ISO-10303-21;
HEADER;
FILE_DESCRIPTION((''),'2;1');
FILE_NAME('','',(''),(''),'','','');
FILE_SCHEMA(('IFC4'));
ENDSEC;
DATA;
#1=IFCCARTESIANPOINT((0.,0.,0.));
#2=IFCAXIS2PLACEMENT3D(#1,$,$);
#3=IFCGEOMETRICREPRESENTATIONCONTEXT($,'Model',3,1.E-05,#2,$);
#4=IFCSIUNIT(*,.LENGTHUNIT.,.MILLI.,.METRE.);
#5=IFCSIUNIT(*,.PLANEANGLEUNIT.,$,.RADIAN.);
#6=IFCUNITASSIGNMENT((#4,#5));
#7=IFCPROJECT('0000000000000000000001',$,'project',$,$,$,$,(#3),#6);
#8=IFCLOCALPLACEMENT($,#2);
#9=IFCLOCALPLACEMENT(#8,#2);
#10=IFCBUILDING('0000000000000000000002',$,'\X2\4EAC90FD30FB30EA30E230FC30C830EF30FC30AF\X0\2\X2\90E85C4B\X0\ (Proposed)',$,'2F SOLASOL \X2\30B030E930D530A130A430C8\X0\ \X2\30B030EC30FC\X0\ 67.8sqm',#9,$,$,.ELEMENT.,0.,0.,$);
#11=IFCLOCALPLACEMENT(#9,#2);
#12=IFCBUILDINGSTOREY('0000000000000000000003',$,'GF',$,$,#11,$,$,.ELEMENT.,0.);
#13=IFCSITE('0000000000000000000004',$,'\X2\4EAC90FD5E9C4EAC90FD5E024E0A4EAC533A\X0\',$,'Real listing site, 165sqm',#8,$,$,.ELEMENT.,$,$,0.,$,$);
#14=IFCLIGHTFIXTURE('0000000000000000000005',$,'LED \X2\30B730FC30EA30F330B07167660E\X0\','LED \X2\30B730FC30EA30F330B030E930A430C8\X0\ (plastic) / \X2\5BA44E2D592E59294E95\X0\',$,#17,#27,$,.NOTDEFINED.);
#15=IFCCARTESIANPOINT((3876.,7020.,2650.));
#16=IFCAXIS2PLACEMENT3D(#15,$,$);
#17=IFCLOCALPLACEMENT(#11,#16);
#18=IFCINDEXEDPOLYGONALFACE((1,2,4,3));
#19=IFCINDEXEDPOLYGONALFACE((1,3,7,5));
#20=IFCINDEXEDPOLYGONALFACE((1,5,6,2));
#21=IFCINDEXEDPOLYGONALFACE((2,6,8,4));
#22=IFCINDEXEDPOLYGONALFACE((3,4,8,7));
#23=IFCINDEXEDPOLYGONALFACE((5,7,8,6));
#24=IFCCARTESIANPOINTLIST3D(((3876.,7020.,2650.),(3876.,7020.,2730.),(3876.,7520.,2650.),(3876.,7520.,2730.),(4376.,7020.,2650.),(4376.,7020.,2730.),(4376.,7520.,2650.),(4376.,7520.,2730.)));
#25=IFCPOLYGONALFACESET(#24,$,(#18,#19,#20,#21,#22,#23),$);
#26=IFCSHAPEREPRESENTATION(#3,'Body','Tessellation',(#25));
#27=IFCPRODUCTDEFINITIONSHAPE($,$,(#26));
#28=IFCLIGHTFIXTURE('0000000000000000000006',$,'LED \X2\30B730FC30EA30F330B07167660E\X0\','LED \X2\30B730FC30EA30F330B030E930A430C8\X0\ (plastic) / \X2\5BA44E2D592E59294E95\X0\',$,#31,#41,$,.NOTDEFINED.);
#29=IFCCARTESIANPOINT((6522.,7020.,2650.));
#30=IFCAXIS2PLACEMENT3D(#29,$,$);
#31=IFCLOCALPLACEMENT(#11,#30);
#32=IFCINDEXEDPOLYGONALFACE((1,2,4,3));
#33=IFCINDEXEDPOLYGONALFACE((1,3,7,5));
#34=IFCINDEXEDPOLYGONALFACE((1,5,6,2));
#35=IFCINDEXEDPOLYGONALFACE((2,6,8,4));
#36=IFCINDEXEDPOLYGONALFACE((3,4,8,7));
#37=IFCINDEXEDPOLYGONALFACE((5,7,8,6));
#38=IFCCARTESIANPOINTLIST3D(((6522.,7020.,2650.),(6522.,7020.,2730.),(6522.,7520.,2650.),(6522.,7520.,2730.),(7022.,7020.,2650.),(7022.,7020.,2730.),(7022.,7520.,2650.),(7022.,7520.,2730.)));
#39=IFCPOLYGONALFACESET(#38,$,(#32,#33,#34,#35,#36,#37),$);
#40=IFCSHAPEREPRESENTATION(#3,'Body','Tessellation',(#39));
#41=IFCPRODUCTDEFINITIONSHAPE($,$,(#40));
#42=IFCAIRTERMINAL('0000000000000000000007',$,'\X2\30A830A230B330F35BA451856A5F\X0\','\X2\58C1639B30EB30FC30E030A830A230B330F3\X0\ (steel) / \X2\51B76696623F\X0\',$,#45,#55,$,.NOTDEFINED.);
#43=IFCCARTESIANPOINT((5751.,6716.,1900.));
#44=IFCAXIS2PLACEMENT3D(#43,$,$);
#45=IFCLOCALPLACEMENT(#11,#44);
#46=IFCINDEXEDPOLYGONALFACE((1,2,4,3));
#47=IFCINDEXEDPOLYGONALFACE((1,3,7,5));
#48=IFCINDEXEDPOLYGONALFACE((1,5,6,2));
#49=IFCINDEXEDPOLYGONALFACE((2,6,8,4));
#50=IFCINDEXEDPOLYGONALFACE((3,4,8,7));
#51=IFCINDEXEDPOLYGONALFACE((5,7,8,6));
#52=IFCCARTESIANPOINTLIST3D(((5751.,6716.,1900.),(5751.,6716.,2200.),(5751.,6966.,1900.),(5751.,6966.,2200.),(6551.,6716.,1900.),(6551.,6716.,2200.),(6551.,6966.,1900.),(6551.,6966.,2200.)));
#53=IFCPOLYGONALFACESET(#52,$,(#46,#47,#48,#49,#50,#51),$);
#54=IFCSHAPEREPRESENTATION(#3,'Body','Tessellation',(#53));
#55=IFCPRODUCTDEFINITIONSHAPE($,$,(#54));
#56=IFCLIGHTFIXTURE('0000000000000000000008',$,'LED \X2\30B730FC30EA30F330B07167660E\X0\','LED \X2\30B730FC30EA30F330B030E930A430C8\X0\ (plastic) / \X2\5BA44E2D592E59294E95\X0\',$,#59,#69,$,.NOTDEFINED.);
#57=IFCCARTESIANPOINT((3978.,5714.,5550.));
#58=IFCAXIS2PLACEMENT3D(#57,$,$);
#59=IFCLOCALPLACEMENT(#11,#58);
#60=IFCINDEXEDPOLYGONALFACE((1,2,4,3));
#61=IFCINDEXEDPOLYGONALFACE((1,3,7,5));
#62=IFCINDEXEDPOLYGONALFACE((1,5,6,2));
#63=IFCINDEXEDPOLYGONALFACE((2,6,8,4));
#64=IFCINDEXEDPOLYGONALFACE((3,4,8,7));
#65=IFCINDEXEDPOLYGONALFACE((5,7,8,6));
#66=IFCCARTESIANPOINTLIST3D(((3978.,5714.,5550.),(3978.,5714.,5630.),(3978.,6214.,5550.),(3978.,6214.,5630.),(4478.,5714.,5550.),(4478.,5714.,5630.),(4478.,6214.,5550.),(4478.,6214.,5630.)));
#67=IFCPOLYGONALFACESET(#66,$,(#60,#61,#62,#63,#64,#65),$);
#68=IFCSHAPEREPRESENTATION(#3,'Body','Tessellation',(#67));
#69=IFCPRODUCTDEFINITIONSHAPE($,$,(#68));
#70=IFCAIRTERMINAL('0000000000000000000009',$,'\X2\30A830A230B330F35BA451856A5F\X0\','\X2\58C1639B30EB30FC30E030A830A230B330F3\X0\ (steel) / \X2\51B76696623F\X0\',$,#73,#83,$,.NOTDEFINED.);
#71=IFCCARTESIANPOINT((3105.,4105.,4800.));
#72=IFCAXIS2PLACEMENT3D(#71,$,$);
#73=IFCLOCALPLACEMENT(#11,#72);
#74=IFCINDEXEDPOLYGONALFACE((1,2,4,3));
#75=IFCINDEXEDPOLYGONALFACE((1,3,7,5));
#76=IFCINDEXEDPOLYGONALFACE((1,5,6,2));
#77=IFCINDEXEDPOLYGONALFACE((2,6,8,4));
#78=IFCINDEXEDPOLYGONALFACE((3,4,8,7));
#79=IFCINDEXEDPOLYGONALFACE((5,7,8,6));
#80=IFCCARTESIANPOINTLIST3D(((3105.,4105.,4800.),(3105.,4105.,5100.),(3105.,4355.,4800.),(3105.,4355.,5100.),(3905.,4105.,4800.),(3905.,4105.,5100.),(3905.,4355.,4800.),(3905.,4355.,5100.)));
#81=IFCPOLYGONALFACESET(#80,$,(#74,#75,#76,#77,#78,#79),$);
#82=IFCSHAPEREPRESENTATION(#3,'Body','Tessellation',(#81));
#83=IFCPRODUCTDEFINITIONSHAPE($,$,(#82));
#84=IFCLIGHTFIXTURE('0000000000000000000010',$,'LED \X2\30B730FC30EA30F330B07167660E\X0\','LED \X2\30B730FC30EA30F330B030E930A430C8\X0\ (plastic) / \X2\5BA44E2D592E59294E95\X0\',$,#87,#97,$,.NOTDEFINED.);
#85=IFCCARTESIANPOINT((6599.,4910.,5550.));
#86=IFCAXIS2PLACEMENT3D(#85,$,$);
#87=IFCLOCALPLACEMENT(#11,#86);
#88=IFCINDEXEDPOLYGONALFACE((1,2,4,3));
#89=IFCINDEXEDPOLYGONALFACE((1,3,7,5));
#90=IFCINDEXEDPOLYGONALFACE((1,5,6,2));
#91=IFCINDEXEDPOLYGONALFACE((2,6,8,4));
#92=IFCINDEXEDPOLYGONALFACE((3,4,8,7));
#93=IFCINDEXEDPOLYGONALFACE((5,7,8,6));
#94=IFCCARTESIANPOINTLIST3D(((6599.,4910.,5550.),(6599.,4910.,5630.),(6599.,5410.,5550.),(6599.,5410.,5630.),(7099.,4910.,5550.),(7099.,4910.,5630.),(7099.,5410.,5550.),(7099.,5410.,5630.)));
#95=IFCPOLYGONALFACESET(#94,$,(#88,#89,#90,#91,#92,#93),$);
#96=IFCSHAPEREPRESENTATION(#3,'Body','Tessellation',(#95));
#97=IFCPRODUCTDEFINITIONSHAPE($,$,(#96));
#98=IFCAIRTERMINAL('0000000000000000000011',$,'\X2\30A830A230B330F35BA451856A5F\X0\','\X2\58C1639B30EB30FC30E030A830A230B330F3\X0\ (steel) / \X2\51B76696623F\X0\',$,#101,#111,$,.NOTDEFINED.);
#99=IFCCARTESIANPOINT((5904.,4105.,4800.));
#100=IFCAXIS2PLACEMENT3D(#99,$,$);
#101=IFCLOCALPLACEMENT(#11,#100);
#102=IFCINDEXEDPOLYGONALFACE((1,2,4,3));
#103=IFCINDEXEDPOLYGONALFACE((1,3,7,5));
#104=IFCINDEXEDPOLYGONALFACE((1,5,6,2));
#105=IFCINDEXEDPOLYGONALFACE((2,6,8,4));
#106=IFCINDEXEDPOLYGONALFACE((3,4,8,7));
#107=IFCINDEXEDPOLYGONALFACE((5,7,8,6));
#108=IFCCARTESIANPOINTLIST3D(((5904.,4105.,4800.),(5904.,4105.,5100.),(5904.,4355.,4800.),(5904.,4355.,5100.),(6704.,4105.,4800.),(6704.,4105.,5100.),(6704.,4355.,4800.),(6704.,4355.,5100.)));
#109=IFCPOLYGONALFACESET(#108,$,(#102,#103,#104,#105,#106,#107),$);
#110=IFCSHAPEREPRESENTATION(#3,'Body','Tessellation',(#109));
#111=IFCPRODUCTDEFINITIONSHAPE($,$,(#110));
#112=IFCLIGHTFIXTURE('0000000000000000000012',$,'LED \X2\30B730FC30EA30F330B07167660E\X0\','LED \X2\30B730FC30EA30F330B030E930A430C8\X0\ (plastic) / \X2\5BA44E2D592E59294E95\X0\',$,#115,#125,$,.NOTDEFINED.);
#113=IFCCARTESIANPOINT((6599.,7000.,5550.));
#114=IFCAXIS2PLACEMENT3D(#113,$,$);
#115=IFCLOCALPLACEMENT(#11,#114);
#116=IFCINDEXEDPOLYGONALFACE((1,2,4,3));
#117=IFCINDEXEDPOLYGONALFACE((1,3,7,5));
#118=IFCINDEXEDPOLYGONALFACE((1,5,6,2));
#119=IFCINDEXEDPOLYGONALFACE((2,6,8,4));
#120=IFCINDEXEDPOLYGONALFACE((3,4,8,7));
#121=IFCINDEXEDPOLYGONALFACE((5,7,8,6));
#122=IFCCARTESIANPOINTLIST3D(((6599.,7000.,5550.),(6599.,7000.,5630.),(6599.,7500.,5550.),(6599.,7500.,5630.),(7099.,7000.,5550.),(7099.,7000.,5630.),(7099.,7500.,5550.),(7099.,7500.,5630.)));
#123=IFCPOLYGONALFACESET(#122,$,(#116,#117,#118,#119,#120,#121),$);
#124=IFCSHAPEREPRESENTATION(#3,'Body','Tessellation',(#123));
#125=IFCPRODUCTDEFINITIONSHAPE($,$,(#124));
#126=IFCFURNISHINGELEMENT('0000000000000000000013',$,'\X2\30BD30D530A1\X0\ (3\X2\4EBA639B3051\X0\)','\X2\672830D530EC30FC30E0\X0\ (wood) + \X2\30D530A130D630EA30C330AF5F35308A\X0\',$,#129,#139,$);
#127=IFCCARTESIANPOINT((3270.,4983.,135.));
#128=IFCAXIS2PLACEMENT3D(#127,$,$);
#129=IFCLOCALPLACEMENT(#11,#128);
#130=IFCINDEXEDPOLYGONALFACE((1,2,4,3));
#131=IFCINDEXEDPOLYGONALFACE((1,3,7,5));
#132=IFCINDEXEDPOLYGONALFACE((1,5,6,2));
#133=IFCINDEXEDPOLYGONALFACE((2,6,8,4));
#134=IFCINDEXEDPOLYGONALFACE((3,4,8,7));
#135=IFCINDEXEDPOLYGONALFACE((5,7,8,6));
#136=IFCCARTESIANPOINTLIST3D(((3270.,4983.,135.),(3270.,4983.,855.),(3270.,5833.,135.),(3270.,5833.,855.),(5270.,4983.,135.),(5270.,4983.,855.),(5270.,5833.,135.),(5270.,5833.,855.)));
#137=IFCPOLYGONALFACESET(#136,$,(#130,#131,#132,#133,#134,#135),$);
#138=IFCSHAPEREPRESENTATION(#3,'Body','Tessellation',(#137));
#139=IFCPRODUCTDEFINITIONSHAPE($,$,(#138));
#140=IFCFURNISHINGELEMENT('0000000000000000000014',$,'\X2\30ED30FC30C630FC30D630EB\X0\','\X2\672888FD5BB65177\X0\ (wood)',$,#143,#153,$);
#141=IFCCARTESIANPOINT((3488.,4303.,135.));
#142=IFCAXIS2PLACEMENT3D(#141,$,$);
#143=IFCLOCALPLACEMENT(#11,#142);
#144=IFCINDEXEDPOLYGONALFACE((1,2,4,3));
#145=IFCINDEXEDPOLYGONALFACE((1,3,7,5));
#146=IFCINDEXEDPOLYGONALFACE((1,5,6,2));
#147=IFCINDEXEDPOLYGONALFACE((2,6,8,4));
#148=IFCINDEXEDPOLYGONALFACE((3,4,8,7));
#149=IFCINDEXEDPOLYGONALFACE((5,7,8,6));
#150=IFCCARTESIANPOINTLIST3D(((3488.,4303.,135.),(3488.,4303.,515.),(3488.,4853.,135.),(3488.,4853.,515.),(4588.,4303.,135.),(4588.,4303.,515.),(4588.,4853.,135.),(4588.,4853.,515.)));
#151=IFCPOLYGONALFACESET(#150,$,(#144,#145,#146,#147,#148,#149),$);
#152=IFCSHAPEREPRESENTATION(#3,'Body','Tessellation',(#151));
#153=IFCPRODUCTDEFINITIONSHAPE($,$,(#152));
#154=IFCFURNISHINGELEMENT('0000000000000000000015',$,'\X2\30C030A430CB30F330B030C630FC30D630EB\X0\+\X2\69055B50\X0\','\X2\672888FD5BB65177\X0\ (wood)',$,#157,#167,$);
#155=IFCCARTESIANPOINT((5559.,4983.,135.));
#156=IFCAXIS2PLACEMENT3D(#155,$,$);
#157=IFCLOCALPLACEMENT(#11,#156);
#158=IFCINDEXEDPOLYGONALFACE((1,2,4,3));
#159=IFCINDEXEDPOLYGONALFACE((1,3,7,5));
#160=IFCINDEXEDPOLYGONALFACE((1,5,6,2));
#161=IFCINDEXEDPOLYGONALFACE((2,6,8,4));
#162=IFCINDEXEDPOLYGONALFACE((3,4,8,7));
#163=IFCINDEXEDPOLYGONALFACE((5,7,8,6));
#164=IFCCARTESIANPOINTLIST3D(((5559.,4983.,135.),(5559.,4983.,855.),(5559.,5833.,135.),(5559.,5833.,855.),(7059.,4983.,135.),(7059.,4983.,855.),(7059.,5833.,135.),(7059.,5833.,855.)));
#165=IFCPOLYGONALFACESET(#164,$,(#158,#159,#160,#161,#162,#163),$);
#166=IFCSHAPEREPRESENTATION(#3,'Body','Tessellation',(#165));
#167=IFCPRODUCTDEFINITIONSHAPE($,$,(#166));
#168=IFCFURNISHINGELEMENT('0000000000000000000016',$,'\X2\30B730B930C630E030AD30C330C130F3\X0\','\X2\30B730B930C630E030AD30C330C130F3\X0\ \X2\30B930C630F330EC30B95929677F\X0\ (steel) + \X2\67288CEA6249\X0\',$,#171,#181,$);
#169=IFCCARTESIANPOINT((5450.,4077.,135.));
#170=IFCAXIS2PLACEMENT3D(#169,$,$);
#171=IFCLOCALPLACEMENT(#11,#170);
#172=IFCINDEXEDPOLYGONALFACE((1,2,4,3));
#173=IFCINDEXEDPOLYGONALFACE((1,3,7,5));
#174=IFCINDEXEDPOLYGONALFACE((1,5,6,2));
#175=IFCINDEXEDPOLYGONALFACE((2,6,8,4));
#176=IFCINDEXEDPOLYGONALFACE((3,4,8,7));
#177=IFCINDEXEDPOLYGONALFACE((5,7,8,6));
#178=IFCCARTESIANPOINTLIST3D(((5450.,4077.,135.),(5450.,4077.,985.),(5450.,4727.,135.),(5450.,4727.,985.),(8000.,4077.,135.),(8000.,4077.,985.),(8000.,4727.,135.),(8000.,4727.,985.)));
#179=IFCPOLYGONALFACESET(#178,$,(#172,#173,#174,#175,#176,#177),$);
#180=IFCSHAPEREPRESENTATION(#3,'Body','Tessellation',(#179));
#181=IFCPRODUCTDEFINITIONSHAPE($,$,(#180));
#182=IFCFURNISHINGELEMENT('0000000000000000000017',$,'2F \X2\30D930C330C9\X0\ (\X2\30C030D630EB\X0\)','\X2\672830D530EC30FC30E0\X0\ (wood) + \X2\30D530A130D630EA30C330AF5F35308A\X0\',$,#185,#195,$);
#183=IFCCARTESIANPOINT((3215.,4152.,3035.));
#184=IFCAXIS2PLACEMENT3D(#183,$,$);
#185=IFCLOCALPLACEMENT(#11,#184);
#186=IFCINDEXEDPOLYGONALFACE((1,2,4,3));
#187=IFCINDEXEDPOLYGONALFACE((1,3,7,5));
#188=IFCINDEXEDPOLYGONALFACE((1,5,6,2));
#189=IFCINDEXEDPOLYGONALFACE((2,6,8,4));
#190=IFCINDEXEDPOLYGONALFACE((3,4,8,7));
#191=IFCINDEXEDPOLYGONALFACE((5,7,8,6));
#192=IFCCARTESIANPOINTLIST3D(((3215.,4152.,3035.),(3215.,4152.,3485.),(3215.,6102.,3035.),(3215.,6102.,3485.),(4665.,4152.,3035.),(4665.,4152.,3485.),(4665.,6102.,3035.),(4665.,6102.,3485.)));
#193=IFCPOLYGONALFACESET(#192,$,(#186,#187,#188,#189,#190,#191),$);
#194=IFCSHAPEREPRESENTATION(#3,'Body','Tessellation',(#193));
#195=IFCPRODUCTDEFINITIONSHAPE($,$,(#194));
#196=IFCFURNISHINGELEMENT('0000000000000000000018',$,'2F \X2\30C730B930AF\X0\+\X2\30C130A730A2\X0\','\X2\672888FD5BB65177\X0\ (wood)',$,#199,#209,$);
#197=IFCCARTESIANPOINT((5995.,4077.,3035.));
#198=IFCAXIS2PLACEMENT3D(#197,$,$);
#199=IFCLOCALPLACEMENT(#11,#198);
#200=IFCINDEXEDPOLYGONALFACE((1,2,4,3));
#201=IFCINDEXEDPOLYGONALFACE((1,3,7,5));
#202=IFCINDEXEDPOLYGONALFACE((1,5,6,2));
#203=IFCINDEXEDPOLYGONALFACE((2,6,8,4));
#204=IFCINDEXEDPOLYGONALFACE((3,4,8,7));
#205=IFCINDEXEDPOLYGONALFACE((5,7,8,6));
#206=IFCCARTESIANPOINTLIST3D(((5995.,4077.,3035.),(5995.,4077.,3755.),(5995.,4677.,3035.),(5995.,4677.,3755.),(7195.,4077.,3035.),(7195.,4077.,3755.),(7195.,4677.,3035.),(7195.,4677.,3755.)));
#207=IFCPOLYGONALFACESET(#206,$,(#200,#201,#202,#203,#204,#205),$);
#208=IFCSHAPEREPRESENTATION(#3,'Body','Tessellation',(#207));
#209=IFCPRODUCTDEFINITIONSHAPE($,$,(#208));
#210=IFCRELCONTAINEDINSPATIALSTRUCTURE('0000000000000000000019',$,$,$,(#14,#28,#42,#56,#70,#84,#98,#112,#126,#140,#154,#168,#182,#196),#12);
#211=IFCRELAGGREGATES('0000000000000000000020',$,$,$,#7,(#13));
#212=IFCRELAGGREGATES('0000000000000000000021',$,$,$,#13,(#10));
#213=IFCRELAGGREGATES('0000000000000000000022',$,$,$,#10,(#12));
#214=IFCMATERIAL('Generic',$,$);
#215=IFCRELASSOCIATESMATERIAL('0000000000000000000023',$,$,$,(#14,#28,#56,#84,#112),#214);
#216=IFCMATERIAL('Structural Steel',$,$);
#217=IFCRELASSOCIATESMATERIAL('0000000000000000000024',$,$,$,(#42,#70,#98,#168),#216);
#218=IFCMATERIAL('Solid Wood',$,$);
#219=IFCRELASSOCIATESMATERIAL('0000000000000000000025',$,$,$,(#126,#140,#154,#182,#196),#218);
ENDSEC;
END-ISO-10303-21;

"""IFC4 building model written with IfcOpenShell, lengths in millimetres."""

from ifc_helpers import new_model, si_unit, frame, frame_2d, origin, place, context, project, spatial, rectangle, extrude, material, element, save


model = new_model("IFC4")

# Units and contexts
model_context = context("Model", 3, precision=1e-05, world=origin())
ifc_project = project(units=[si_unit("LENGTHUNIT", "METRE", prefix="MILLI"), si_unit("PLANEANGLEUNIT", "RADIAN")], contexts=[model_context])

# Site, building, storey
site_placement = place(None, origin())
site = spatial("IfcSite", under=ifc_project, at=site_placement, Name="京都府京都市上京区", ObjectType="Real listing site, 165sqm", CompositionType="ELEMENT", RefElevation=0.0)
building_placement = place(site_placement, origin())
building = spatial("IfcBuilding", under=site, at=building_placement, Name="京都・リモートワーク2部屋 (Proposed)", ObjectType="2F SOLASOL グラファイト グレー 67.8sqm", CompositionType="ELEMENT", ElevationOfRefHeight=0.0, ElevationOfTerrain=0.0)
storey_placement = place(building_placement, origin())
storey = spatial("IfcBuildingStorey", under=building, at=storey_placement, Name="GF", CompositionType="ELEMENT", Elevation=0.0)

# Shared definitions
ifc_material_1 = material(Name="Solid Wood")

# Shared definitions
ifc_material_2 = material(Name="Structural Steel")

# Shared definitions
ifc_material_3 = material(Name="Generic")

# Light fixtures
light_fixture_1_placement = place(storey_placement, frame((3876.0, 7020.0, 2650.0)))
element("IfcLightFixture", 1, at=light_fixture_1_placement, inside=storey, material=ifc_material_3, Name="LED シーリング照明", Description="LED シーリングライト (plastic) / 室中央天井", PredefinedType="NOTDEFINED", context=model_context, shape_type="SweptSolid", body=[
    extrude(rectangle(XDim=500.0, YDim=500.0, at=frame_2d((250.0, 250.0))), frame((3876.0, 7020.0, 2650.0)), (0.0, 0.0, 1.0), 80.0),
])
light_fixture_2_placement = place(storey_placement, frame((6522.0, 7020.0, 2650.0)))
element("IfcLightFixture", 2, at=light_fixture_2_placement, inside=storey, material=ifc_material_3, Name="LED シーリング照明", Description="LED シーリングライト (plastic) / 室中央天井", PredefinedType="NOTDEFINED", context=model_context, shape_type="SweptSolid", body=[
    extrude(rectangle(XDim=500.0, YDim=500.0, at=frame_2d((250.0, 250.0))), frame((6522.0, 7020.0, 2650.0)), (0.0, 0.0, 1.0), 80.0),
])

# Air terminal
air_terminal_1_placement = place(storey_placement, frame((5751.0, 6716.0, 1900.0)))
element("IfcAirTerminal", 3, at=air_terminal_1_placement, inside=storey, material=ifc_material_2, Name="エアコン室内機", Description="壁掛ルームエアコン (steel) / 冷暖房", PredefinedType="NOTDEFINED", context=model_context, shape_type="SweptSolid", body=[
    extrude(rectangle(XDim=800.0, YDim=250.0, at=frame_2d((400.0, 125.0))), frame((5751.0, 6716.0, 1900.0)), (0.0, 0.0, 1.0), 300.0),
])

# Light fixture
light_fixture_3_placement = place(storey_placement, frame((3978.0, 5714.0, 5550.0)))
element("IfcLightFixture", 4, at=light_fixture_3_placement, inside=storey, material=ifc_material_3, Name="LED シーリング照明", Description="LED シーリングライト (plastic) / 室中央天井", PredefinedType="NOTDEFINED", context=model_context, shape_type="SweptSolid", body=[
    extrude(rectangle(XDim=500.0, YDim=500.0, at=frame_2d((250.0, 250.0))), frame((3978.0, 5714.0, 5550.0)), (0.0, 0.0, 1.0), 80.0),
])

# Air terminal
air_terminal_2_placement = place(storey_placement, frame((3105.0, 4105.0, 4800.0)))
element("IfcAirTerminal", 5, at=air_terminal_2_placement, inside=storey, material=ifc_material_2, Name="エアコン室内機", Description="壁掛ルームエアコン (steel) / 冷暖房", PredefinedType="NOTDEFINED", context=model_context, shape_type="SweptSolid", body=[
    extrude(rectangle(XDim=800.0, YDim=250.0, at=frame_2d((400.0, 125.0))), frame((3105.0, 4105.0, 4800.0)), (0.0, 0.0, 1.0), 300.0),
])

# Light fixture
light_fixture_4_placement = place(storey_placement, frame((6599.0, 4910.0, 5550.0)))
element("IfcLightFixture", 6, at=light_fixture_4_placement, inside=storey, material=ifc_material_3, Name="LED シーリング照明", Description="LED シーリングライト (plastic) / 室中央天井", PredefinedType="NOTDEFINED", context=model_context, shape_type="SweptSolid", body=[
    extrude(rectangle(XDim=500.0, YDim=500.0, at=frame_2d((250.0, 250.0))), frame((6599.0, 4910.0, 5550.0)), (0.0, 0.0, 1.0), 80.0),
])

# Air terminal
air_terminal_3_placement = place(storey_placement, frame((5904.0, 4105.0, 4800.0)))
element("IfcAirTerminal", 7, at=air_terminal_3_placement, inside=storey, material=ifc_material_2, Name="エアコン室内機", Description="壁掛ルームエアコン (steel) / 冷暖房", PredefinedType="NOTDEFINED", context=model_context, shape_type="SweptSolid", body=[
    extrude(rectangle(XDim=800.0, YDim=250.0, at=frame_2d((400.0, 125.0))), frame((5904.0, 4105.0, 4800.0)), (0.0, 0.0, 1.0), 300.0),
])

# Light fixture
light_fixture_5_placement = place(storey_placement, frame((6599.0, 7000.0, 5550.0)))
element("IfcLightFixture", 8, at=light_fixture_5_placement, inside=storey, material=ifc_material_3, Name="LED シーリング照明", Description="LED シーリングライト (plastic) / 室中央天井", PredefinedType="NOTDEFINED", context=model_context, shape_type="SweptSolid", body=[
    extrude(rectangle(XDim=500.0, YDim=500.0, at=frame_2d((250.0, 250.0))), frame((6599.0, 7000.0, 5550.0)), (0.0, 0.0, 1.0), 80.0),
])

# Furnishing elements
furnishing_1_placement = place(storey_placement, frame((3270.0, 4983.0, 135.0)))
element("IfcFurnishingElement", 9, at=furnishing_1_placement, inside=storey, material=ifc_material_1, Name="ソファ (3人掛け)", Description="木フレーム (wood) + ファブリック張り", context=model_context, shape_type="SweptSolid", body=[
    extrude(rectangle(XDim=2000.0, YDim=850.0, at=frame_2d((1000.0, 425.0))), frame((3270.0, 4983.0, 135.0)), (0.0, 0.0, 1.0), 720.0),
])
furnishing_2_placement = place(storey_placement, frame((3488.0, 4303.0, 135.0)))
element("IfcFurnishingElement", 10, at=furnishing_2_placement, inside=storey, material=ifc_material_1, Name="ローテーブル", Description="木製家具 (wood)", context=model_context, shape_type="SweptSolid", body=[
    extrude(rectangle(XDim=1100.0, YDim=550.0, at=frame_2d((550.0, 275.0))), frame((3488.0, 4303.0, 135.0)), (0.0, 0.0, 1.0), 380.0),
])
furnishing_3_placement = place(storey_placement, frame((5559.0, 4983.0, 135.0)))
element("IfcFurnishingElement", 11, at=furnishing_3_placement, inside=storey, material=ifc_material_1, Name="ダイニングテーブル+椅子", Description="木製家具 (wood)", context=model_context, shape_type="SweptSolid", body=[
    extrude(rectangle(XDim=1500.0, YDim=850.0, at=frame_2d((750.0, 425.0))), frame((5559.0, 4983.0, 135.0)), (0.0, 0.0, 1.0), 720.0),
])
furnishing_4_placement = place(storey_placement, frame((5450.0, 4077.0, 135.0)))
element("IfcFurnishingElement", 12, at=furnishing_4_placement, inside=storey, material=ifc_material_2, Name="システムキッチン", Description="システムキッチン ステンレス天板 (steel) + 木質扉", context=model_context, shape_type="SweptSolid", body=[
    extrude(rectangle(XDim=2550.0, YDim=650.0, at=frame_2d((1275.0, 325.0))), frame((5450.0, 4077.0, 135.0)), (0.0, 0.0, 1.0), 850.0),
])
furnishing_5_placement = place(storey_placement, frame((3215.0, 4152.0, 3035.0)))
element("IfcFurnishingElement", 13, at=furnishing_5_placement, inside=storey, material=ifc_material_1, Name="2F ベッド (ダブル)", Description="木フレーム (wood) + ファブリック張り", context=model_context, shape_type="SweptSolid", body=[
    extrude(rectangle(XDim=1450.0, YDim=1950.0, at=frame_2d((725.0, 975.0))), frame((3215.0, 4152.0, 3035.0)), (0.0, 0.0, 1.0), 450.0),
])
furnishing_6_placement = place(storey_placement, frame((5995.0, 4077.0, 3035.0)))
element("IfcFurnishingElement", 14, at=furnishing_6_placement, inside=storey, material=ifc_material_1, Name="2F デスク+チェア", Description="木製家具 (wood)", context=model_context, shape_type="SweptSolid", body=[
    extrude(rectangle(XDim=1200.0, YDim=600.0, at=frame_2d((600.0, 300.0))), frame((5995.0, 4077.0, 3035.0)), (0.0, 0.0, 1.0), 720.0),
])

save(model, "model.ifc")
